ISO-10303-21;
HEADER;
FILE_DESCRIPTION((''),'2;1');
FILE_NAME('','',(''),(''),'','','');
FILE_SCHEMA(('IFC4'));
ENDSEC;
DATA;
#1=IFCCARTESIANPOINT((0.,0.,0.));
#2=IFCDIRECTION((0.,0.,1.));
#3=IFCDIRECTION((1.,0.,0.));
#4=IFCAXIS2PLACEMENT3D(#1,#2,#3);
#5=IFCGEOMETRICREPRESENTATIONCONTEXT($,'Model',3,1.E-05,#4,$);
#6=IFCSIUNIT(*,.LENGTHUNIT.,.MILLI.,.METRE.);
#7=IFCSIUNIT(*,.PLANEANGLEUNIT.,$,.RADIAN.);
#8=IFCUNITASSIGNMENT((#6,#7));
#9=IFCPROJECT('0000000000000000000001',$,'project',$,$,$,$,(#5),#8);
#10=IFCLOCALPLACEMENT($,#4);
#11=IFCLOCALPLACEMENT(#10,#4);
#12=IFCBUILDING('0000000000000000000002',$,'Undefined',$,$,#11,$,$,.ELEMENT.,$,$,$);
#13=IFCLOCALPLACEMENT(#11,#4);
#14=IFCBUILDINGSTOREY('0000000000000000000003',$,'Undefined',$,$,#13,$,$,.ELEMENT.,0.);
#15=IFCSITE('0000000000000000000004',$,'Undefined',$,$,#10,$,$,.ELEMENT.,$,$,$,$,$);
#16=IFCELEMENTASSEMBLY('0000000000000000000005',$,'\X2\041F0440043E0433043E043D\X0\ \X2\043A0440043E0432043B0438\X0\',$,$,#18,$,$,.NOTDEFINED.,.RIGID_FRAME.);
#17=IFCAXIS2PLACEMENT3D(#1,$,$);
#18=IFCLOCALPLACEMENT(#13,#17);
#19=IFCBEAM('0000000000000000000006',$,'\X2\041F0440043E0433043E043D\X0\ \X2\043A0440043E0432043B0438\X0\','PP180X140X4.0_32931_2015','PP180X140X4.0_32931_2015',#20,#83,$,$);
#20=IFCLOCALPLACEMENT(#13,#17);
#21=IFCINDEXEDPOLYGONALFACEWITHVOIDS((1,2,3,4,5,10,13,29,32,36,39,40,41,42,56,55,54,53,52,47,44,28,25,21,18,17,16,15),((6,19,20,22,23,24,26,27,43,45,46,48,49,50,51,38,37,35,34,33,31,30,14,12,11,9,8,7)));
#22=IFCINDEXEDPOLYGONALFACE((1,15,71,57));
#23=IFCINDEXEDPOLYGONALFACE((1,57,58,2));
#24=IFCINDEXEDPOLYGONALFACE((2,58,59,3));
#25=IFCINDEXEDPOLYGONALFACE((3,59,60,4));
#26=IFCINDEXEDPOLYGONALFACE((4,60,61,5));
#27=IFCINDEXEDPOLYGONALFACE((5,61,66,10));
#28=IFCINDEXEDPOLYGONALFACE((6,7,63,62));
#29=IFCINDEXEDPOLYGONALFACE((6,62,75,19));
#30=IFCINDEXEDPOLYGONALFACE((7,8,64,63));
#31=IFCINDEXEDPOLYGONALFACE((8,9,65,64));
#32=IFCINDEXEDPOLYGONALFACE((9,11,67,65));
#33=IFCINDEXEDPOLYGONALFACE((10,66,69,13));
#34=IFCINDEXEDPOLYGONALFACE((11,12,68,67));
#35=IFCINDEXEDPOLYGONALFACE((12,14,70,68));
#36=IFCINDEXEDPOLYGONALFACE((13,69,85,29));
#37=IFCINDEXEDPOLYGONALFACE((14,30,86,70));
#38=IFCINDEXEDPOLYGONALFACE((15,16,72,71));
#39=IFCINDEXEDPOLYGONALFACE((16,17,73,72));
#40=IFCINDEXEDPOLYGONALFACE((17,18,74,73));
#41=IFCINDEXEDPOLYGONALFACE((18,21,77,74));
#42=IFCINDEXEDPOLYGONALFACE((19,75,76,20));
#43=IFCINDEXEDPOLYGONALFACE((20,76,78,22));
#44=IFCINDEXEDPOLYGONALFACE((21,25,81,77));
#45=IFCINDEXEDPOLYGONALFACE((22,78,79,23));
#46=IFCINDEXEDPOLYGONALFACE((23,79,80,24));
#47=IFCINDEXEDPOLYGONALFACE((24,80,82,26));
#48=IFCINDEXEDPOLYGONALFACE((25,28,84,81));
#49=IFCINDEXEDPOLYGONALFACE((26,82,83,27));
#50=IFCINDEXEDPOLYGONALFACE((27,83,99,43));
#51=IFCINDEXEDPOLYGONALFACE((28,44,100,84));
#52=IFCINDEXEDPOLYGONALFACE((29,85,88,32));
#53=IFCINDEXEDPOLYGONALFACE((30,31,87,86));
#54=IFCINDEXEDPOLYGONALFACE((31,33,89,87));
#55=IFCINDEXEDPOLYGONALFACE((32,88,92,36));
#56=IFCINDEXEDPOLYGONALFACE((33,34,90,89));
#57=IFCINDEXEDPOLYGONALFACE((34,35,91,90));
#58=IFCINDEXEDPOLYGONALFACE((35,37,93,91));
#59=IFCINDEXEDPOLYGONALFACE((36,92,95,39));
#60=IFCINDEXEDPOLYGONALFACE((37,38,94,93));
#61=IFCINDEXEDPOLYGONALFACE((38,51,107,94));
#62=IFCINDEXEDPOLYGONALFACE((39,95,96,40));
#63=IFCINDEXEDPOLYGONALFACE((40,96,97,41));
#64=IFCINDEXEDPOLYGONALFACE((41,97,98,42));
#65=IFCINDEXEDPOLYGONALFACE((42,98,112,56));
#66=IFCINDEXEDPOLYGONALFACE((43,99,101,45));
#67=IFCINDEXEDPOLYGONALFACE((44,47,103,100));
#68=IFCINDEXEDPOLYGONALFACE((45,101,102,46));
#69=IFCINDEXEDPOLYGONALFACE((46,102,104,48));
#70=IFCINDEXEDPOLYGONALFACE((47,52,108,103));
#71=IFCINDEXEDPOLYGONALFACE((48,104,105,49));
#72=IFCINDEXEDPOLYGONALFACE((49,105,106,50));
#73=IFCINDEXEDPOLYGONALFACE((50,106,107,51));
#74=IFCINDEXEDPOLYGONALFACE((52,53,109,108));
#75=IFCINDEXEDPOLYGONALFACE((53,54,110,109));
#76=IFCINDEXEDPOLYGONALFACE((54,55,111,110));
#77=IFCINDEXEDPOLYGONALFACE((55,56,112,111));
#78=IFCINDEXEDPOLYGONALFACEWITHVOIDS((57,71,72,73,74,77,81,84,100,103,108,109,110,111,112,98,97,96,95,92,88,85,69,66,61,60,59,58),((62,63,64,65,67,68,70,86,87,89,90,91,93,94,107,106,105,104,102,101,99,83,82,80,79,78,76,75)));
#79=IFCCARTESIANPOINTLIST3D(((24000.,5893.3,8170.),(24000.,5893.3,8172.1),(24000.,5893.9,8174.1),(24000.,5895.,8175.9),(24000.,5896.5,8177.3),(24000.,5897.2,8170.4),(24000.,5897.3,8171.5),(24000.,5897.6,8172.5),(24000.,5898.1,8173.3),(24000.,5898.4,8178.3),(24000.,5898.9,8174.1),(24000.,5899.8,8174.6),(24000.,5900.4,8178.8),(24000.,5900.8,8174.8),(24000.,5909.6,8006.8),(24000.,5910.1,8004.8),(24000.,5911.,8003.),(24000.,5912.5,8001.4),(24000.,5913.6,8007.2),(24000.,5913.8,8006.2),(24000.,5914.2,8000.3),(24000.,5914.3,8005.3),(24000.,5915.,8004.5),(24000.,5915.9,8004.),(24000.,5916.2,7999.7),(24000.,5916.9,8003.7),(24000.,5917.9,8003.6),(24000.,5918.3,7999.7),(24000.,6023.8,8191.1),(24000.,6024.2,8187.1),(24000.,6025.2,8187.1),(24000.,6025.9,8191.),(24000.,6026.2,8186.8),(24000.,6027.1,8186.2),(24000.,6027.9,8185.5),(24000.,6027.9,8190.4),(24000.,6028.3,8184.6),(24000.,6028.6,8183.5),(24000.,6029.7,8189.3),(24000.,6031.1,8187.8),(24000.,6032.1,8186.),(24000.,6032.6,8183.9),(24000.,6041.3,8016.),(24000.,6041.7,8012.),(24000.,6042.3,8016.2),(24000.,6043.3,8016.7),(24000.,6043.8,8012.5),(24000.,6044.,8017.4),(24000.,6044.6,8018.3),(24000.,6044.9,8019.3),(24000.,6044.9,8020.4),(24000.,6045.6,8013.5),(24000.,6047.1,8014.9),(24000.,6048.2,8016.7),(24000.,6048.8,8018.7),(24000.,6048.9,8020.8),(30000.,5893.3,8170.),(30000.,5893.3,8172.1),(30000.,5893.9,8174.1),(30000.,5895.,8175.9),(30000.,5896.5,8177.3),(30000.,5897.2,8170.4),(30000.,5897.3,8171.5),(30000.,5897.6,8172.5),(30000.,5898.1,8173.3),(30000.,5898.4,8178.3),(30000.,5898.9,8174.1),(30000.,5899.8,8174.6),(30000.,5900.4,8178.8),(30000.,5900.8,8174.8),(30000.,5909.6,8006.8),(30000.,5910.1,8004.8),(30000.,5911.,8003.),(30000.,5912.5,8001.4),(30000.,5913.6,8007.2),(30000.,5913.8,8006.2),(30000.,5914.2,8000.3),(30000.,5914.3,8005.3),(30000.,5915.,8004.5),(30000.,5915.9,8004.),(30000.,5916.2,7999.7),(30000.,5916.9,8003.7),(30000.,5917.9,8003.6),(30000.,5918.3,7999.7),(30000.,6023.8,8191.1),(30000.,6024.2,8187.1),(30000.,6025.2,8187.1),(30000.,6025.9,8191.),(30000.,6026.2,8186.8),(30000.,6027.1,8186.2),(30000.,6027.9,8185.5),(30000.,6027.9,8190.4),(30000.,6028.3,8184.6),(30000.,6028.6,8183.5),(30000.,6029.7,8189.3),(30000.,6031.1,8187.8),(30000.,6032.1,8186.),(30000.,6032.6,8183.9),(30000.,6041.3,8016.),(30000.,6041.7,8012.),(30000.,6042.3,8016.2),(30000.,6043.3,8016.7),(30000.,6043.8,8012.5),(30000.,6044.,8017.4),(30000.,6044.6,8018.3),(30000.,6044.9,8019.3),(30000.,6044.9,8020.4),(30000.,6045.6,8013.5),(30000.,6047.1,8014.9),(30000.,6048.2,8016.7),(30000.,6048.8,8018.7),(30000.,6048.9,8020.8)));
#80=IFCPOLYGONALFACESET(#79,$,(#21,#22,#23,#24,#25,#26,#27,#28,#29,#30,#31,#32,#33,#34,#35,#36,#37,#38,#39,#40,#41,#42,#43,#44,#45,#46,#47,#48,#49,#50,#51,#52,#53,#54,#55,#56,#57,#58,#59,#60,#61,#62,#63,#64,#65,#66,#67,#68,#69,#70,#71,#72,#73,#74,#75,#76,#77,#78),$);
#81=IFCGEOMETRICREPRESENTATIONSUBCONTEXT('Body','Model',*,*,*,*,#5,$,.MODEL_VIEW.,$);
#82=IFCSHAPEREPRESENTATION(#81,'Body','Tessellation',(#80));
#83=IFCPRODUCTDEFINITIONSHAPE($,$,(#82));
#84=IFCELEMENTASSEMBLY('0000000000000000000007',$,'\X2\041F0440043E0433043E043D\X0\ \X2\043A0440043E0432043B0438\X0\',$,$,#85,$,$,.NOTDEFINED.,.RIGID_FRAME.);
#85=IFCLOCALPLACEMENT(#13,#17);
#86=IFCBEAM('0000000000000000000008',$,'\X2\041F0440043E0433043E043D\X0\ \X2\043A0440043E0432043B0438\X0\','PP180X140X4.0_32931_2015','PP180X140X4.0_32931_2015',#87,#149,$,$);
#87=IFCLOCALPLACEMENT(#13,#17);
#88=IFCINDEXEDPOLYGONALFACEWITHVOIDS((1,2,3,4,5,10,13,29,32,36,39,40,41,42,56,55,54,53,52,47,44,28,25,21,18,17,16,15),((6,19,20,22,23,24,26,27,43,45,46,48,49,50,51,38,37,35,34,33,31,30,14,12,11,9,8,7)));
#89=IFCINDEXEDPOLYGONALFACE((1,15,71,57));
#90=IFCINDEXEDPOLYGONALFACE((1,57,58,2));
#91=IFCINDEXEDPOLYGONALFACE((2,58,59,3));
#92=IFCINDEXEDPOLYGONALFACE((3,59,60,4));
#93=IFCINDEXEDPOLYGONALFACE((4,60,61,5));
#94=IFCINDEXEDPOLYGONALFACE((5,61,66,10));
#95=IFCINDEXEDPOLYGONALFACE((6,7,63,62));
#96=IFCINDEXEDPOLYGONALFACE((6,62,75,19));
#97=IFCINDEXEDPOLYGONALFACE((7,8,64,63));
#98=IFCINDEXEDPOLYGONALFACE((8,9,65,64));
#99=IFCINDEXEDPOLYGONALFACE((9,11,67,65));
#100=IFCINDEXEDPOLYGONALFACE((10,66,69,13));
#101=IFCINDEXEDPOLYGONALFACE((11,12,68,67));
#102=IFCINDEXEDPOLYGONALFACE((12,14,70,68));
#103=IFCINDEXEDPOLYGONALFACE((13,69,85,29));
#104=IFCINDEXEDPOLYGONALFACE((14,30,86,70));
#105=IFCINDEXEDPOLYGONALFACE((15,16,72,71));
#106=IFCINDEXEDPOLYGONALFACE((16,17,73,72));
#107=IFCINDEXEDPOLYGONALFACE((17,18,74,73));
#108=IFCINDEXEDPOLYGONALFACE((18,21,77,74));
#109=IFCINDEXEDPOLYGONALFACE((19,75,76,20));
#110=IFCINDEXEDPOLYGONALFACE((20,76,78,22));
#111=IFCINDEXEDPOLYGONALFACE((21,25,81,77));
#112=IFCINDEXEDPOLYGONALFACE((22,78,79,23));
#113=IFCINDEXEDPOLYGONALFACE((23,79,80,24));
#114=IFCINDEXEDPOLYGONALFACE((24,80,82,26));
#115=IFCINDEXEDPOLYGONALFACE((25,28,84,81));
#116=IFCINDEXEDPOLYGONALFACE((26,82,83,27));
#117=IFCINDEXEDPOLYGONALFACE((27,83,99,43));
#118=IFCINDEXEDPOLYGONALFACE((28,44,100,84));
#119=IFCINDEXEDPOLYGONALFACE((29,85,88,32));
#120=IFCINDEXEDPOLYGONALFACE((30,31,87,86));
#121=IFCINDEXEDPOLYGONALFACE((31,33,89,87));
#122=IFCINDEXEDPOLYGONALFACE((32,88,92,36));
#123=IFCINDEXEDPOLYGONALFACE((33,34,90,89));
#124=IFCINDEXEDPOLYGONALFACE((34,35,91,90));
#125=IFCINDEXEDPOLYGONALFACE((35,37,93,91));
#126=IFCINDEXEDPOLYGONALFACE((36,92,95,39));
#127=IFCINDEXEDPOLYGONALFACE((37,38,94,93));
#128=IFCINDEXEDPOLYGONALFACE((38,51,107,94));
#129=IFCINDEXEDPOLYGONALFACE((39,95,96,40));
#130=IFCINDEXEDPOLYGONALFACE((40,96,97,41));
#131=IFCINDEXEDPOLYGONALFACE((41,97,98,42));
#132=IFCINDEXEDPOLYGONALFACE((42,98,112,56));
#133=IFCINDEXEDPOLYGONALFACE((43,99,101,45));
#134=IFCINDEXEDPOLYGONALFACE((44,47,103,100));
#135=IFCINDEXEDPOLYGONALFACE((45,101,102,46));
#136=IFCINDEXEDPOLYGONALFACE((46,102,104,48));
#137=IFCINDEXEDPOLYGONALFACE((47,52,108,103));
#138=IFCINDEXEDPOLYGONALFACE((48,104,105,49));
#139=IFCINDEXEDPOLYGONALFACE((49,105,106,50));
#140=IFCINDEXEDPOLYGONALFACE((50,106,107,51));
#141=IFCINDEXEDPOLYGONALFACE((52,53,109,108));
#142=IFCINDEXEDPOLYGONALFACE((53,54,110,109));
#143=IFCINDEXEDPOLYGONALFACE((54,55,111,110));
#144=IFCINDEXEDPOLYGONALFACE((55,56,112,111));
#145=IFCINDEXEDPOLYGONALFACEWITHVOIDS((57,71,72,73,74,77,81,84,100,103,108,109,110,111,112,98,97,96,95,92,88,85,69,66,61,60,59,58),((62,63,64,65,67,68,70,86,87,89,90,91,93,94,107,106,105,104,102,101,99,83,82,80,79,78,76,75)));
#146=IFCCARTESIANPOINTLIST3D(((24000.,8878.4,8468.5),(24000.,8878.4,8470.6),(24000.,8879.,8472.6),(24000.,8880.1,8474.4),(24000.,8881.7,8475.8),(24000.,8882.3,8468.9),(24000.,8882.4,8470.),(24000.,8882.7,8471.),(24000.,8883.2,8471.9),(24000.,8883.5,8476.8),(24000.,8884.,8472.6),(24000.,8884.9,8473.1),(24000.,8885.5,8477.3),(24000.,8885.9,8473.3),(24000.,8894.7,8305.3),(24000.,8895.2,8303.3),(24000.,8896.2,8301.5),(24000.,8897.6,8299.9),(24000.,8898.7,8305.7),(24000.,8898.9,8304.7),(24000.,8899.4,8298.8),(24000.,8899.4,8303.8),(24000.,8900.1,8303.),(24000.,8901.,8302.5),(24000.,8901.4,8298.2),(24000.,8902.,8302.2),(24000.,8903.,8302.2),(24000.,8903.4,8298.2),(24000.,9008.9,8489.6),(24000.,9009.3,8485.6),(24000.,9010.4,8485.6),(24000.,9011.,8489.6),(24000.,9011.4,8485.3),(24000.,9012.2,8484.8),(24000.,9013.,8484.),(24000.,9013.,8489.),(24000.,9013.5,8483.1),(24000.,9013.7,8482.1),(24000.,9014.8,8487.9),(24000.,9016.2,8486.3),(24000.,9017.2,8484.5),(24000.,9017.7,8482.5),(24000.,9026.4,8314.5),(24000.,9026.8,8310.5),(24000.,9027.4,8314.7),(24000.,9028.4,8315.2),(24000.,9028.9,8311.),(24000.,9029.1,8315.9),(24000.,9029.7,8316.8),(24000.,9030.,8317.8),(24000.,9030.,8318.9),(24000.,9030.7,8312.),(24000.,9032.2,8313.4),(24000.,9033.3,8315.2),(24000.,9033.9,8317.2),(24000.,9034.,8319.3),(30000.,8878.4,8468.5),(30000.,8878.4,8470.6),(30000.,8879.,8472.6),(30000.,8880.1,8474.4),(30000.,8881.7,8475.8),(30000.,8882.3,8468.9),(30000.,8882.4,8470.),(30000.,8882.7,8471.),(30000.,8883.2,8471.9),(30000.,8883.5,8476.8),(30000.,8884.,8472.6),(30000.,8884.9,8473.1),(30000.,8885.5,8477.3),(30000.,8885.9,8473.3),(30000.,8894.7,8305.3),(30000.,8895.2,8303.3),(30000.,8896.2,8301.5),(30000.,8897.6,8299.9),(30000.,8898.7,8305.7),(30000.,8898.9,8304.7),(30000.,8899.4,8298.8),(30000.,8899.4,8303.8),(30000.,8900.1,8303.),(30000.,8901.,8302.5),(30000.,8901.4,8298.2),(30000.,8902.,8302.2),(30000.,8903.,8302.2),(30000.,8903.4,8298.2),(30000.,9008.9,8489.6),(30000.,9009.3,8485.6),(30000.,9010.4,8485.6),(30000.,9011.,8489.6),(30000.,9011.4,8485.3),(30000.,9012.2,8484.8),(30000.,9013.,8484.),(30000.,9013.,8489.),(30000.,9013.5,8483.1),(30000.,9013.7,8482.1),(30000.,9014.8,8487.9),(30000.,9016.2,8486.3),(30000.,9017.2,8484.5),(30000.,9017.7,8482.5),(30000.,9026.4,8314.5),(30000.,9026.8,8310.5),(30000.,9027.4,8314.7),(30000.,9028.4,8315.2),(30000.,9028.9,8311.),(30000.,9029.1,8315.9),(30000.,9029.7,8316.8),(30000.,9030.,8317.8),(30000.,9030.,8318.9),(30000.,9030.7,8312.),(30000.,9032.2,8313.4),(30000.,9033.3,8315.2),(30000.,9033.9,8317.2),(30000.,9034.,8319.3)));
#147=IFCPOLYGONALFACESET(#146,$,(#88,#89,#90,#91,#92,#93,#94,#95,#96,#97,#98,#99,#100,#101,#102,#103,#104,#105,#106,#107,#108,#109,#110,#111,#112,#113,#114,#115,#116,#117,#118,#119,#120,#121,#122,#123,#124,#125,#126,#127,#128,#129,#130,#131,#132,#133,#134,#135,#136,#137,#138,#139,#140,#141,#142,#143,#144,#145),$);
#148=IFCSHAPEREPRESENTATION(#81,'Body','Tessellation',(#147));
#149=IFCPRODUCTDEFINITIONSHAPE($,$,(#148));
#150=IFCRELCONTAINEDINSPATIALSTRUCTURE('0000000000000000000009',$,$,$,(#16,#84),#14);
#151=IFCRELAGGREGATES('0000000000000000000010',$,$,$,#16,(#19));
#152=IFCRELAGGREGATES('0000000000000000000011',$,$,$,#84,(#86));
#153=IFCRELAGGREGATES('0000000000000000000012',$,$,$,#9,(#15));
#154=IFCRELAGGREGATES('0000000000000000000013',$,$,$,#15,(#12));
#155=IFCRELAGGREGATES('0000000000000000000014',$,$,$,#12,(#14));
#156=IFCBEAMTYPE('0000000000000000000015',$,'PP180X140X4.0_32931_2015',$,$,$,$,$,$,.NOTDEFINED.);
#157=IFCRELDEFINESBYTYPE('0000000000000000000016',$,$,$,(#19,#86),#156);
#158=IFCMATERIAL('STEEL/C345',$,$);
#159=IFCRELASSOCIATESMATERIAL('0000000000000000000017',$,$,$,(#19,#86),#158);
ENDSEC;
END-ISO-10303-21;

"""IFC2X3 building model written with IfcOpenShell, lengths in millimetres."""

from ifc_helpers import new_model, si_unit, frame, origin_with_axes, origin_2d_with_axis, place, context, subcontext, project, spatial, hollow_rectangle, extrude, material, type_object, element, aggregate, save


model = new_model("IFC2X3")

# Units and contexts
model_context = context("Model", 3, precision=1e-05, world=origin_with_axes())
body_context = subcontext(model_context, "Body", "Model", "MODEL_VIEW")
ifc_project = project(units=[si_unit("LENGTHUNIT", "METRE", prefix="MILLI"), si_unit("PLANEANGLEUNIT", "RADIAN")], contexts=[model_context])

# Site, building, storey
site_placement = place(None, origin_with_axes())
site = spatial("IfcSite", under=ifc_project, at=site_placement, Name="Undefined", CompositionType="ELEMENT")
building_placement = place(site_placement, origin_with_axes())
building = spatial("IfcBuilding", under=site, at=building_placement, Name="Undefined", CompositionType="ELEMENT")
storey_placement = place(building_placement, origin_with_axes())
storey = spatial("IfcBuildingStorey", under=building, at=storey_placement, Name="Undefined", CompositionType="ELEMENT", Elevation=0.0)

# Element assemblies, beams
ifc_material_1 = material(Name="STEEL/C345")
beam_type_1 = type_object("IfcBeamType", Name="PP180X140X4.0_32931_2015", PredefinedType="NOTDEFINED")
assembly_1_placement = place(storey_placement, origin_with_axes())
assembly_1 = element("IfcElementAssembly", 1, at=assembly_1_placement, inside=storey, Name="Прогон кровли", AssemblyPlace="NOTDEFINED", PredefinedType="RIGID_FRAME")
beam_1_placement = place(assembly_1_placement, frame((24000.0, 5971.1, 8095.4), z_axis=(0.0, -0.099504, 0.995037), x_axis=(1.0, 0.0, 0.0)))
beam_1 = element("IfcBeam", 2, at=beam_1_placement, type_object=beam_type_1, material=ifc_material_1, Name="Прогон кровли", Description="PP180X140X4.0_32931_2015", ObjectType="PP180X140X4.0_32931_2015", context=body_context, shape_type="SweptSolid", body=[
    extrude(hollow_rectangle(XDim=140.0, YDim=180.0, WallThickness=4.0, InnerFilletRadius=4.0, OuterFilletRadius=8.0, at=origin_2d_with_axis()), frame((6000.0, 0.0, 0.0), z_axis=(-1.0, 0.0, 0.0), x_axis=(0.0, -1.0, 0.0)), (0.0, 0.0, 1.0), 6000.0),
])
aggregate(assembly_1, [beam_1])
assembly_2_placement = place(storey_placement, origin_with_axes())
assembly_2 = element("IfcElementAssembly", 3, at=assembly_2_placement, inside=storey, Name="Прогон кровли", AssemblyPlace="NOTDEFINED", PredefinedType="RIGID_FRAME")
beam_2_placement = place(assembly_2_placement, frame((24000.0, 8956.2, 8393.9), z_axis=(0.0, -0.099504, 0.995037), x_axis=(1.0, 0.0, 0.0)))
beam_2 = element("IfcBeam", 4, at=beam_2_placement, type_object=beam_type_1, material=ifc_material_1, Name="Прогон кровли", Description="PP180X140X4.0_32931_2015", ObjectType="PP180X140X4.0_32931_2015", context=body_context, shape_type="SweptSolid", body=[
    extrude(hollow_rectangle(XDim=140.0, YDim=180.0, WallThickness=4.0, InnerFilletRadius=4.0, OuterFilletRadius=8.0, at=origin_2d_with_axis()), frame((6000.0, 0.0, 0.0), z_axis=(-1.0, 0.0, 0.0), x_axis=(0.0, -1.0, 0.0)), (0.0, 0.0, 1.0), 6000.0),
])
aggregate(assembly_2, [beam_2])

save(model, "model.ifc")
